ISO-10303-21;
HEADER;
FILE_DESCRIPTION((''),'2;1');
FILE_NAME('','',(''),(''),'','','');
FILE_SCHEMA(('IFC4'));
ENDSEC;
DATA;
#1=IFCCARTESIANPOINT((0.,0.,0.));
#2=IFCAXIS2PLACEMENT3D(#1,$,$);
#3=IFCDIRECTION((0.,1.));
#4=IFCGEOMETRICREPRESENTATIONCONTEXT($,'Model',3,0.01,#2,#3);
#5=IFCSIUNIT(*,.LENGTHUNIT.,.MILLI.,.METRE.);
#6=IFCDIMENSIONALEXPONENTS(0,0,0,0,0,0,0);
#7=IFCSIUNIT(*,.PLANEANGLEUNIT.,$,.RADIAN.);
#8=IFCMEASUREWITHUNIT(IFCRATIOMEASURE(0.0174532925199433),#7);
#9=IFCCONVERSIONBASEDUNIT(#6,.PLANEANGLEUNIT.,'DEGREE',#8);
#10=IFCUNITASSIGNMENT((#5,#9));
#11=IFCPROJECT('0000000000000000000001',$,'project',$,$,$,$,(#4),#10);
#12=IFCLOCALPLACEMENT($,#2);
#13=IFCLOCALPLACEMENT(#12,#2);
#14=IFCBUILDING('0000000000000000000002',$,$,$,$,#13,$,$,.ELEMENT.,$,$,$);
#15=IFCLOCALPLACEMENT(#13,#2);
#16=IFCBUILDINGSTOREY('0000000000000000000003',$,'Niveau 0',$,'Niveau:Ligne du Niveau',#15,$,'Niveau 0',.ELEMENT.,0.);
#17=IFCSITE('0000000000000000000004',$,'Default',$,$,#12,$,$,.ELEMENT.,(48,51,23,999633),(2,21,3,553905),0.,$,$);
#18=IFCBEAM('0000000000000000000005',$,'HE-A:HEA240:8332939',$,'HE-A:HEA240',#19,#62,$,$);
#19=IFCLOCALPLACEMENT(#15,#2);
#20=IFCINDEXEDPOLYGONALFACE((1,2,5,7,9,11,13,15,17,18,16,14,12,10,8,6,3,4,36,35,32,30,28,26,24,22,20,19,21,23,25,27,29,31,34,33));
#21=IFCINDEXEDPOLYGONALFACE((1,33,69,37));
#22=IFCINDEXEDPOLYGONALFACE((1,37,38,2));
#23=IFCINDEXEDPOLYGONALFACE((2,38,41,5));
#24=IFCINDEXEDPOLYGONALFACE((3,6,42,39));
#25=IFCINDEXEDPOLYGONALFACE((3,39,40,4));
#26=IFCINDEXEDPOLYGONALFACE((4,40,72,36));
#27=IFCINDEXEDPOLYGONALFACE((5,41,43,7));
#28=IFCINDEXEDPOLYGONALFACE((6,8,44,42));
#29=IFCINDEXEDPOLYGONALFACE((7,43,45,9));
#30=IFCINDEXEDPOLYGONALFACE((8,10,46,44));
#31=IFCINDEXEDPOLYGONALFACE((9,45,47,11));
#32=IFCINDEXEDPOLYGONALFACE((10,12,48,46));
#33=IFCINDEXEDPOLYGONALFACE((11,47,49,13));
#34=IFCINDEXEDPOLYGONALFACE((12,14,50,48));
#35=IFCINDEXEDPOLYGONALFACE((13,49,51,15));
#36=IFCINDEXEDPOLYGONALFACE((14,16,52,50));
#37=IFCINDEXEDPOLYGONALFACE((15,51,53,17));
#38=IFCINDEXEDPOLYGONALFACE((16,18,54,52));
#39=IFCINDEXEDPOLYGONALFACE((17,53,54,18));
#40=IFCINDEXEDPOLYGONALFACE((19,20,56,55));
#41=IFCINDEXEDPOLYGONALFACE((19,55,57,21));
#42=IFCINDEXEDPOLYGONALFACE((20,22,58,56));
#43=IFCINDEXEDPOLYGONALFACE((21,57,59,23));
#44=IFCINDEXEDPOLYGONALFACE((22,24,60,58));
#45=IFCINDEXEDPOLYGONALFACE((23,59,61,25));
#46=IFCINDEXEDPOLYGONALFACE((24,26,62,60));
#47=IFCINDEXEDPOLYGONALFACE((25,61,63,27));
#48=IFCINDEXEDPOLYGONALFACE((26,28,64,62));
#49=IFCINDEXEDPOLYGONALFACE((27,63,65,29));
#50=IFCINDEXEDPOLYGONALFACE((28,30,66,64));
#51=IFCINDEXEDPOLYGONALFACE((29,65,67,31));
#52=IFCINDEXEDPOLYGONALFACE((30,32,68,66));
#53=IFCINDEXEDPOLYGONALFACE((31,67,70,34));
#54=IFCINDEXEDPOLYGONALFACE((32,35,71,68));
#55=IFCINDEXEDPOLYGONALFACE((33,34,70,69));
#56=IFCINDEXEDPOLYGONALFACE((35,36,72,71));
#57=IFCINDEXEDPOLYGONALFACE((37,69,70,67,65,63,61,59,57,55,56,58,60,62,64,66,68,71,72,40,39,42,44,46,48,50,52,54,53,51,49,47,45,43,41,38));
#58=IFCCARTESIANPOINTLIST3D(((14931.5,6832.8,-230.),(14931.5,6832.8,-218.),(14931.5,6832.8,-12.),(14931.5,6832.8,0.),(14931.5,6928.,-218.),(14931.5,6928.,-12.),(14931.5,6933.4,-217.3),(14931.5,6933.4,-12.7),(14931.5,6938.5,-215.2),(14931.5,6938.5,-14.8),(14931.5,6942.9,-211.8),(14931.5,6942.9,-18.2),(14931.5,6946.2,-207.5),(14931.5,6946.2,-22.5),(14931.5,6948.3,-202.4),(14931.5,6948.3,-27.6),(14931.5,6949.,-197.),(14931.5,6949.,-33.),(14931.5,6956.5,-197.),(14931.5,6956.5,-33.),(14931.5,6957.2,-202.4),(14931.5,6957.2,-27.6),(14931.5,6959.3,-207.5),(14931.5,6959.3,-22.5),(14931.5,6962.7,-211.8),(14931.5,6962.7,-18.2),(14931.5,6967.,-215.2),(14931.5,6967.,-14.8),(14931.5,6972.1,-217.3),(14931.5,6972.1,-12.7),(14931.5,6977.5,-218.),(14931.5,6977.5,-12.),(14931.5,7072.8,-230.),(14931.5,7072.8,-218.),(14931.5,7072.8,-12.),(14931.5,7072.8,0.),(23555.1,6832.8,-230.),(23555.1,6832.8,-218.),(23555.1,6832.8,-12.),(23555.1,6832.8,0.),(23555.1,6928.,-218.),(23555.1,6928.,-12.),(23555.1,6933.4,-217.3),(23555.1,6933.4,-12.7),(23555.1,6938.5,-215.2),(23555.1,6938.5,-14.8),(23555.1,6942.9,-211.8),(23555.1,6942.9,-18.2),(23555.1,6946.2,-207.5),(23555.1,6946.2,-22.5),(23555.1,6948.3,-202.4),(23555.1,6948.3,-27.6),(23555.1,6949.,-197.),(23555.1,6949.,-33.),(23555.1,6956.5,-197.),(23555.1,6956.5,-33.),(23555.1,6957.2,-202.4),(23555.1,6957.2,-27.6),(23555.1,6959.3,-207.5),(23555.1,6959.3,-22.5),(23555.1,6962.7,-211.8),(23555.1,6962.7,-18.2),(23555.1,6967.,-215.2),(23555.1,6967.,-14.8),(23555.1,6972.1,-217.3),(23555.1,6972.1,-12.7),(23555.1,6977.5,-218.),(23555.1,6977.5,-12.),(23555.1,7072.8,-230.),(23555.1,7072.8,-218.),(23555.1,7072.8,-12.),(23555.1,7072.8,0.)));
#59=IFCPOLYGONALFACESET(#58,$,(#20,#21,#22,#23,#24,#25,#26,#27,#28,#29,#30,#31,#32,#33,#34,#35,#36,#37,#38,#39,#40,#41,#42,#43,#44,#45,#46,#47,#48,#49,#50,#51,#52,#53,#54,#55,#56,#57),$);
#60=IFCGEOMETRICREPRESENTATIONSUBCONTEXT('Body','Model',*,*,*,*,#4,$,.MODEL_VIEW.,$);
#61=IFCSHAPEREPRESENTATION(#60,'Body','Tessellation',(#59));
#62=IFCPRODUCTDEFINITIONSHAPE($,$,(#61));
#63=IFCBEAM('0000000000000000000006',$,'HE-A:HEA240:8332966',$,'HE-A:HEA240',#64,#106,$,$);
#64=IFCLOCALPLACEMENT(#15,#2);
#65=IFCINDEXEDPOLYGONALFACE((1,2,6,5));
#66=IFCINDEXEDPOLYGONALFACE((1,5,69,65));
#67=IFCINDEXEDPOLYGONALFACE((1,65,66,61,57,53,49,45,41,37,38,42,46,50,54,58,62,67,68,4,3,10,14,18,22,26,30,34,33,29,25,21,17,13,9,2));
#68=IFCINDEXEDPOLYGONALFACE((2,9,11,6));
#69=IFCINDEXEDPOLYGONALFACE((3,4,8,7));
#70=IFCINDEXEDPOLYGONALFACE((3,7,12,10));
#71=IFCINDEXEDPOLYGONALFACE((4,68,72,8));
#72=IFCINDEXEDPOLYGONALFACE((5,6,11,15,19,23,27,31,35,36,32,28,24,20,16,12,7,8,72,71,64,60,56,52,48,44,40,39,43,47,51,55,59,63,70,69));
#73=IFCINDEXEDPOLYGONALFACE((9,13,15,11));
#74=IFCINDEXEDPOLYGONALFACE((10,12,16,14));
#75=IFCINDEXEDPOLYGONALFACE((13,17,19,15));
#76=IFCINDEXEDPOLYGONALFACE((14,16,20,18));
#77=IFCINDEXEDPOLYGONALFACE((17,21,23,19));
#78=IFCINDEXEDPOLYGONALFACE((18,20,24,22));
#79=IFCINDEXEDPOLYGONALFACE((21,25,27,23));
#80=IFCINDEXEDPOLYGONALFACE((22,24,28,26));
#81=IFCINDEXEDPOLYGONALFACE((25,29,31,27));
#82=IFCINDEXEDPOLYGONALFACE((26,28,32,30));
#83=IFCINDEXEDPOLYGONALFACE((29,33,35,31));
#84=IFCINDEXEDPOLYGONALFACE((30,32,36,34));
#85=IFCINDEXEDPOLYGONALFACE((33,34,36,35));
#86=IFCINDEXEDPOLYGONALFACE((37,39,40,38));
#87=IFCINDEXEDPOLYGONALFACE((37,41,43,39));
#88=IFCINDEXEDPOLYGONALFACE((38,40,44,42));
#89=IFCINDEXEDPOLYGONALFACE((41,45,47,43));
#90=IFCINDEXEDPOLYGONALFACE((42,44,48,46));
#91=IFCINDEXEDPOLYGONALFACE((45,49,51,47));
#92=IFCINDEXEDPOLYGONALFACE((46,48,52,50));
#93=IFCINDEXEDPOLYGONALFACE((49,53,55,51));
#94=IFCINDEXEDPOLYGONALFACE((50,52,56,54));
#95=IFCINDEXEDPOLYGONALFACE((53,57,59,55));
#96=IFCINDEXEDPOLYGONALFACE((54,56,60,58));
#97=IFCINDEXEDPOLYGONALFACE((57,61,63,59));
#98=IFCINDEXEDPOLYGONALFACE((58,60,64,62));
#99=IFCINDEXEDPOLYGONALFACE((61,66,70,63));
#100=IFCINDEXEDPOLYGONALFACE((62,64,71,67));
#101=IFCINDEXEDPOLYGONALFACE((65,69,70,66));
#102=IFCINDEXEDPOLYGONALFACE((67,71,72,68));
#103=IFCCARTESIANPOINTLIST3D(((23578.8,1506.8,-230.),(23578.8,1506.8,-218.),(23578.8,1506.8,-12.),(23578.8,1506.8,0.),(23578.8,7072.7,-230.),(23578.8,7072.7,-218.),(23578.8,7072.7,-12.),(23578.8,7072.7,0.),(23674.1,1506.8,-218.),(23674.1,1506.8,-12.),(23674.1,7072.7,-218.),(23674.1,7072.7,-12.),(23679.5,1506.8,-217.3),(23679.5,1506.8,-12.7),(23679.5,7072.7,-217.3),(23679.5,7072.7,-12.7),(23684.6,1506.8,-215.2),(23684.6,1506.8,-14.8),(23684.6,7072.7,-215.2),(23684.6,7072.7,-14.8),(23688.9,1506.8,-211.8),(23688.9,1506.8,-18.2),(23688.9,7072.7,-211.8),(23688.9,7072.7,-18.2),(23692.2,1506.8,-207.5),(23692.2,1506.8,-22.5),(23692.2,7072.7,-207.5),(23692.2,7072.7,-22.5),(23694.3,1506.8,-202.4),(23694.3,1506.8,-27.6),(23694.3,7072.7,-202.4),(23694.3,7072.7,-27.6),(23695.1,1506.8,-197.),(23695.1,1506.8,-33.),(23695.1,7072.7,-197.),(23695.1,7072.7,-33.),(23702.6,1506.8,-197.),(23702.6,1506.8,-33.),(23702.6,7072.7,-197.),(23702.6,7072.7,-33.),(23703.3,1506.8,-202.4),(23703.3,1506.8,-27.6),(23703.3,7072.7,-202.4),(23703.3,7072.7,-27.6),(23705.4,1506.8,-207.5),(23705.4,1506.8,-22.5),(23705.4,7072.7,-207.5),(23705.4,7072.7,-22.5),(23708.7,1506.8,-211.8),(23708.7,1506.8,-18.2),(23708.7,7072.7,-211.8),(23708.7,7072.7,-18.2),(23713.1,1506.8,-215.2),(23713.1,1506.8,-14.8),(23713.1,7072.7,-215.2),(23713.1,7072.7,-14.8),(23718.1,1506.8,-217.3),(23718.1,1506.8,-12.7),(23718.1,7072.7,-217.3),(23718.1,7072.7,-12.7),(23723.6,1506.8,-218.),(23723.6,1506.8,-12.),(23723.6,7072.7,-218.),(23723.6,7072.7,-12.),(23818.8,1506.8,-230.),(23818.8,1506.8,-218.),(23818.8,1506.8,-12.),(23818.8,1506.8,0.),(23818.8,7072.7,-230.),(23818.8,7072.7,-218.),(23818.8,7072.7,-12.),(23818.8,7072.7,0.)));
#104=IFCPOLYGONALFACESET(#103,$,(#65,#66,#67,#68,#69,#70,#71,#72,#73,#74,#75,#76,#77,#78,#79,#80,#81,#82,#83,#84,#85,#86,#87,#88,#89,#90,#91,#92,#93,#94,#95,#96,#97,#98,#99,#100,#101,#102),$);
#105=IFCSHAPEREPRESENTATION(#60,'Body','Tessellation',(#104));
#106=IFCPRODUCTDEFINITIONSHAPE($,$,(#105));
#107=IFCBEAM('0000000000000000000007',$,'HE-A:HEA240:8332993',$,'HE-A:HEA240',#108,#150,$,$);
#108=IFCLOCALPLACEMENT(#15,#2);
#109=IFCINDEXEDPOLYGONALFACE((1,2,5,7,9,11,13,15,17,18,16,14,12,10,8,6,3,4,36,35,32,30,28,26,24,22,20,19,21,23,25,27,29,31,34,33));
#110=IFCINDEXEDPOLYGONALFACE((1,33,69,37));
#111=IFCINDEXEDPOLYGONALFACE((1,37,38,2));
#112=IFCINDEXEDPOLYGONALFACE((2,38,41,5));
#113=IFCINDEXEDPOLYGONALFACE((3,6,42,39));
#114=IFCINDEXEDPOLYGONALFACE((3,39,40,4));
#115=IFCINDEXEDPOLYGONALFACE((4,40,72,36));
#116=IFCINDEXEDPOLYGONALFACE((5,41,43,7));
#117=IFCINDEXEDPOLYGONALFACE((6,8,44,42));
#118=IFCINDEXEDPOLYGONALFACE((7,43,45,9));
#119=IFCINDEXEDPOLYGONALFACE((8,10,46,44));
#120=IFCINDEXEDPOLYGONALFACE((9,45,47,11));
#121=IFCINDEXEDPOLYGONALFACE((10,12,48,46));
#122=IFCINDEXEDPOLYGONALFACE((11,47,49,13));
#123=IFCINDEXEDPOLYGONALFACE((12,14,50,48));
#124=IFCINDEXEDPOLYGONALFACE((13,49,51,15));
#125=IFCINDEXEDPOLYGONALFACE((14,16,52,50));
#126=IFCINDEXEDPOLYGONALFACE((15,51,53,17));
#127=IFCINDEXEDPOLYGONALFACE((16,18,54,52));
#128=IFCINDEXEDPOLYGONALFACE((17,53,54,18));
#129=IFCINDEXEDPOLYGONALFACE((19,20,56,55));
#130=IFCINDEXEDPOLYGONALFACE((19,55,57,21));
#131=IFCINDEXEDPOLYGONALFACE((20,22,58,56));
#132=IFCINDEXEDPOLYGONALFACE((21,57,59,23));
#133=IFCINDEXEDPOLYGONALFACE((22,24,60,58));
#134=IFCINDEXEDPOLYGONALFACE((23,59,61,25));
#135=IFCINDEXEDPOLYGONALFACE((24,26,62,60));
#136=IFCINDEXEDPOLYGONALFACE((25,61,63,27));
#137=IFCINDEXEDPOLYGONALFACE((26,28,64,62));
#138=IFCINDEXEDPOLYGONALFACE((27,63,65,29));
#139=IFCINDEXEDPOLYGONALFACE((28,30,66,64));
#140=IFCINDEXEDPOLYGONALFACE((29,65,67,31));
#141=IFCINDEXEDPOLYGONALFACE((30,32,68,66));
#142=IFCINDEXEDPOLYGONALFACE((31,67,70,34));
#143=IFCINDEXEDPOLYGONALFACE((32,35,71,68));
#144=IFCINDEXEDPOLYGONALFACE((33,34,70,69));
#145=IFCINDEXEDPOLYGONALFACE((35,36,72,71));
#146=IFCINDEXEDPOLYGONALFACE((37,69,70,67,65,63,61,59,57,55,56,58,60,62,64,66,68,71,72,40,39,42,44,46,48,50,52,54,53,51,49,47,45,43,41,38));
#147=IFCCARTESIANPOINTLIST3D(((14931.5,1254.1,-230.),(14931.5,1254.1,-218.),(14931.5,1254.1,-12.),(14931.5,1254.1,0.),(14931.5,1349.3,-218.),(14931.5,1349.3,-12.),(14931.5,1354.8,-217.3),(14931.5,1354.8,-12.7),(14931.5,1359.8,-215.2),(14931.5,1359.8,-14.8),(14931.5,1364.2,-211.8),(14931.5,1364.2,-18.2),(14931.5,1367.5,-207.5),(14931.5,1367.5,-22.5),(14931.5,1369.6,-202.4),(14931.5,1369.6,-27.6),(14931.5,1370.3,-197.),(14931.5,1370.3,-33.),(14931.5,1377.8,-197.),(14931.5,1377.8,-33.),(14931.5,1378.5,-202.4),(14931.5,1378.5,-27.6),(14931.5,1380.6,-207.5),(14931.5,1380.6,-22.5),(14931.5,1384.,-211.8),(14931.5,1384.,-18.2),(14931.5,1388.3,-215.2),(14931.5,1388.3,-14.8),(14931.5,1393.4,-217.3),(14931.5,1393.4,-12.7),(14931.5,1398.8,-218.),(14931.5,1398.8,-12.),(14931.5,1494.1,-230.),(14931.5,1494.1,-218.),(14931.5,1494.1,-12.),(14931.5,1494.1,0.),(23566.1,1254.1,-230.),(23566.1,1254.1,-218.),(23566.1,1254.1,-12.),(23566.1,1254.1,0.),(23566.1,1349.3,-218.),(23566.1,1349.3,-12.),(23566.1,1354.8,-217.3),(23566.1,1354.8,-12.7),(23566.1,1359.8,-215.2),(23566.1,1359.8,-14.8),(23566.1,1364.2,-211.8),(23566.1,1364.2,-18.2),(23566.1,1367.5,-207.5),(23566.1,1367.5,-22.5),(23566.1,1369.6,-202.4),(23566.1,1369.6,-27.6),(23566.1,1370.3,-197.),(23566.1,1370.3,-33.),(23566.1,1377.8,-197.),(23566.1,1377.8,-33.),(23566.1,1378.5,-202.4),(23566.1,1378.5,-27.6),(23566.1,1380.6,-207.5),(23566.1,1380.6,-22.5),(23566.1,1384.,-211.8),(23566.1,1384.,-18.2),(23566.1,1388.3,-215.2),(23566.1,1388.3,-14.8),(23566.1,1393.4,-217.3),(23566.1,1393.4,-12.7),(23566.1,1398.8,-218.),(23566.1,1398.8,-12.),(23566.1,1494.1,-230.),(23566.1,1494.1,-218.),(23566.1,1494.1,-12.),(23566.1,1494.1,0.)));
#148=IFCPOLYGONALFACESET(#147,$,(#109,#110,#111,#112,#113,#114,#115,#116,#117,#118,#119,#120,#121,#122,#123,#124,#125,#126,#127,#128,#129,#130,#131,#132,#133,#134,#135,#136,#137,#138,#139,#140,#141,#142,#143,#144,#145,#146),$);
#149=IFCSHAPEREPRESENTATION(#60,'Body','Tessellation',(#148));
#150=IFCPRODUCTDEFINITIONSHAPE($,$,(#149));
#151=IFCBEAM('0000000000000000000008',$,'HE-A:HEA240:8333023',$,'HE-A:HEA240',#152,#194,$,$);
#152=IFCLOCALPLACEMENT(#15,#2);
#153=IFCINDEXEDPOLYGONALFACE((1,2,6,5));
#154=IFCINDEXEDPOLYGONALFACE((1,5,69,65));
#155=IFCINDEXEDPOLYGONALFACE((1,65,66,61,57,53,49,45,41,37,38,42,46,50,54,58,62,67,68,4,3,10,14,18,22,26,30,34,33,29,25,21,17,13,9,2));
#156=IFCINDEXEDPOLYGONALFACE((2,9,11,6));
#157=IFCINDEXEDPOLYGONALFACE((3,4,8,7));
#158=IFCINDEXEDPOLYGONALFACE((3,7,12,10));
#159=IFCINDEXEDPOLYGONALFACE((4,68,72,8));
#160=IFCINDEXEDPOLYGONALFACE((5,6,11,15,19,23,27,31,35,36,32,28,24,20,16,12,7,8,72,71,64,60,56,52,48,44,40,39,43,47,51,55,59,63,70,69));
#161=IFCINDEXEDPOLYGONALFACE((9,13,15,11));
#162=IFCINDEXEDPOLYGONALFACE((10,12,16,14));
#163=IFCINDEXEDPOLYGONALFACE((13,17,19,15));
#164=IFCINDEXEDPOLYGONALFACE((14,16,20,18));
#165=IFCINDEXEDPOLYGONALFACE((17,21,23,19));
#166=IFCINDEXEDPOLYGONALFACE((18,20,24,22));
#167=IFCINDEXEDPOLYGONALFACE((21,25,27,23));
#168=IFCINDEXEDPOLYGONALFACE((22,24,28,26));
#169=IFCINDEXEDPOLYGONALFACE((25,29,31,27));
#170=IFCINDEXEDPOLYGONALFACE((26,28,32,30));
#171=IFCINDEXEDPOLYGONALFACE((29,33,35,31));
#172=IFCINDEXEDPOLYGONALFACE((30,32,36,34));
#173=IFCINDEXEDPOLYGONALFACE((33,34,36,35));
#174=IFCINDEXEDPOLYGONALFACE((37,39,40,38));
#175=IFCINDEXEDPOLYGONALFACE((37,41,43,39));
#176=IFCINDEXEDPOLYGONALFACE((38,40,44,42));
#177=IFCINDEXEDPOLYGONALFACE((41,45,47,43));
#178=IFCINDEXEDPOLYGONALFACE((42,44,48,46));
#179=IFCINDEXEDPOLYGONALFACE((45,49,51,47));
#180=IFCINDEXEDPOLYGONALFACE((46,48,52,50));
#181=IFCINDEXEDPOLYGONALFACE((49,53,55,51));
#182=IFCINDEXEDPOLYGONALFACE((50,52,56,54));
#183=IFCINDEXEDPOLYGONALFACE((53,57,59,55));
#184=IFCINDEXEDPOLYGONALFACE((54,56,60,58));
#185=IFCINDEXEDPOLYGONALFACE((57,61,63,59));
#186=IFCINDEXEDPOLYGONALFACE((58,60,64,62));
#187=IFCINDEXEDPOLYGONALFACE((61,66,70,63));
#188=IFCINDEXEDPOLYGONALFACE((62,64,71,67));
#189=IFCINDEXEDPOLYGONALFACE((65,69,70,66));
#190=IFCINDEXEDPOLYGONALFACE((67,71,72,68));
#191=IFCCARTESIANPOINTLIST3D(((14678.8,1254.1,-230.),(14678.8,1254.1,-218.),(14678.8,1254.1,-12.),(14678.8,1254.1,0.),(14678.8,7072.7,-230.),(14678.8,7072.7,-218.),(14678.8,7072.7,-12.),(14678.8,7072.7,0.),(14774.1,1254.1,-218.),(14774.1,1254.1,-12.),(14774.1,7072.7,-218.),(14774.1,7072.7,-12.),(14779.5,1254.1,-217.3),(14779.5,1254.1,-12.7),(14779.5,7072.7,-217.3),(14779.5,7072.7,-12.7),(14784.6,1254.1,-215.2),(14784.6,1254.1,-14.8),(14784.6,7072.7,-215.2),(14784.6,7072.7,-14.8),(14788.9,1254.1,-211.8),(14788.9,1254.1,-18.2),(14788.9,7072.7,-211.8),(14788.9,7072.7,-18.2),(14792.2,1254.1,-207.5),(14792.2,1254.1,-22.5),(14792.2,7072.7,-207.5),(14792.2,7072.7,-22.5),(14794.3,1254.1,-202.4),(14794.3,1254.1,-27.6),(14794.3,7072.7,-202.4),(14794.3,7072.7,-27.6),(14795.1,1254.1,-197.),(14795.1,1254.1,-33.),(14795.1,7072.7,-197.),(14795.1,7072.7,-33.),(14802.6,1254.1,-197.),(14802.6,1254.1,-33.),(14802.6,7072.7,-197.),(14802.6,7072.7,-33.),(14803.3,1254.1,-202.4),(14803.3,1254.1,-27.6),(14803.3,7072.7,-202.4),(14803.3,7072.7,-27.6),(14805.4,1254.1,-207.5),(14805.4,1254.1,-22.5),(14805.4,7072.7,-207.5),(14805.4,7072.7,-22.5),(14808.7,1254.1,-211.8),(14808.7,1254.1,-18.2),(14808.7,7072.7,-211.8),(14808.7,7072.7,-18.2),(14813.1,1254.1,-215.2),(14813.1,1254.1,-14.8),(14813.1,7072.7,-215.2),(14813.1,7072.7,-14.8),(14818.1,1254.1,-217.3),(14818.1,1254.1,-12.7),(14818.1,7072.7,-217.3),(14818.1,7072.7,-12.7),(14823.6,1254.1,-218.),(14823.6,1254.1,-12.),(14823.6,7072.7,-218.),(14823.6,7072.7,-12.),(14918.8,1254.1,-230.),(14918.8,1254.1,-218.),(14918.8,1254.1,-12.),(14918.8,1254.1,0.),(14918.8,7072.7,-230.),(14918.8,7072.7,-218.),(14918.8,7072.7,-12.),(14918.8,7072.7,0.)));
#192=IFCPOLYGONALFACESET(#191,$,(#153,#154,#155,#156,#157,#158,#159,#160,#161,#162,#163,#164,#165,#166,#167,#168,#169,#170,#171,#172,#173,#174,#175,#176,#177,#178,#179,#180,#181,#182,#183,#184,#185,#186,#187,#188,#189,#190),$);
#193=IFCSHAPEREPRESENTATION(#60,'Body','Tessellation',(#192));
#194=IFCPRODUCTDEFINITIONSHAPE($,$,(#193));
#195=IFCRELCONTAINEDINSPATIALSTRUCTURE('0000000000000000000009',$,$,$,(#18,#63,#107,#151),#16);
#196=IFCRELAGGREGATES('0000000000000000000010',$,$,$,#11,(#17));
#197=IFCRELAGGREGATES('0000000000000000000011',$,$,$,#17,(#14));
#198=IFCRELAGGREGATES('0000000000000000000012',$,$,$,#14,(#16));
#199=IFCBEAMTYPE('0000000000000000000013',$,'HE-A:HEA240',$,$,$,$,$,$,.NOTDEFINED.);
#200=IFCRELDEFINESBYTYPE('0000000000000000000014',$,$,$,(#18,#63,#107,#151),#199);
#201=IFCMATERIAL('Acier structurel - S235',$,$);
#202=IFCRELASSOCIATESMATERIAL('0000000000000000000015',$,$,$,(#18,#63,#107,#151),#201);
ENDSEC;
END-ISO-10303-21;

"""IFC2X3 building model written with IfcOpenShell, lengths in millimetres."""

from ifc_helpers import new_model, entity, si_unit, converted_unit, direction, frame, frame_2d, origin, place, context, subcontext, project, spatial, i_section, extrude, material, type_object, element, save


model = new_model("IFC2X3")

# Units and contexts
model_context = context("Model", 3, precision=0.01, world=origin(), true_north=direction((0.0, 1.0)))
body_context = subcontext(model_context, "Body", "Model", "MODEL_VIEW")
ifc_project = project(units=[si_unit("LENGTHUNIT", "METRE", prefix="MILLI"), converted_unit("PLANEANGLEUNIT", "DEGREE", entity("IfcRatioMeasure", 0.0174532925199433), si_unit("PLANEANGLEUNIT", "RADIAN"), dimensions=[0, 0, 0, 0, 0, 0, 0])], contexts=[model_context])

# Site, building, storey
site_placement = place(None, origin())
site = spatial("IfcSite", under=ifc_project, at=site_placement, Name="Default", CompositionType="ELEMENT", RefLatitude=(48, 51, 23, 999633), RefLongitude=(2, 21, 3, 553905), RefElevation=0.0)
building_placement = place(site_placement, origin())
building = spatial("IfcBuilding", under=site, at=building_placement, CompositionType="ELEMENT")
storey_placement = place(building_placement, origin())
storey = spatial("IfcBuildingStorey", under=building, at=storey_placement, Name="Niveau 0", ObjectType="Niveau:Ligne du Niveau", LongName="Niveau 0", CompositionType="ELEMENT", Elevation=0.0)

# Beams
ifc_material_1 = material(Name="Acier structurel - S235")
beam_type = type_object("IfcBeamType", Name="HE-A:HEA240", PredefinedType="NOTDEFINED")
beam_1_placement = place(storey_placement, frame((14798.8, 6952.8, 0.0)))
element("IfcBeam", 1, at=beam_1_placement, inside=storey, type_object=beam_type, material=ifc_material_1, Name="HE-A:HEA240:8332939", ObjectType="HE-A:HEA240", context=body_context, shape_type="SweptSolid", body=[
    extrude(i_section(OverallWidth=240.0, OverallDepth=230.0, WebThickness=7.5, FlangeThickness=12.0, FilletRadius=21.0, at=frame_2d((0.0, 0.0), x_axis=(0.0, 1.0))), frame((132.7, 0.0, -115.0), z_axis=(1.0, 0.0, 0.0), x_axis=(0.0, 0.0, -1.0)), (0.0, 0.0, 1.0), 8623.6),
])
beam_2_placement = place(storey_placement, frame((23698.8, 6952.8, 0.0), z_axis=(0.0, 0.0, 1.0), x_axis=(0.0, -1.0, 0.0)))
element("IfcBeam", 2, at=beam_2_placement, inside=storey, type_object=beam_type, material=ifc_material_1, Name="HE-A:HEA240:8332966", ObjectType="HE-A:HEA240", context=body_context, shape_type="SweptSolid", body=[
    extrude(i_section(OverallWidth=240.0, OverallDepth=230.0, WebThickness=7.5, FlangeThickness=12.0, FilletRadius=21.0, at=frame_2d((0.0, 0.0), x_axis=(0.0, 1.0))), frame((-120.0, 0.0, -115.0), z_axis=(1.0, 0.0, 0.0), x_axis=(0.0, 0.0, -1.0)), (0.0, 0.0, 1.0), 5565.9),
])
beam_3_placement = place(storey_placement, frame((23698.8, 1374.1, 0.0), z_axis=(0.0, 0.0, 1.0), x_axis=(-1.0, 0.0, 0.0)))
element("IfcBeam", 3, at=beam_3_placement, inside=storey, type_object=beam_type, material=ifc_material_1, Name="HE-A:HEA240:8332993", ObjectType="HE-A:HEA240", context=body_context, shape_type="SweptSolid", body=[
    extrude(i_section(OverallWidth=240.0, OverallDepth=230.0, WebThickness=7.5, FlangeThickness=12.0, FilletRadius=21.0, at=frame_2d((0.0, 0.0), x_axis=(0.0, 1.0))), frame((132.7, 0.0, -115.0), z_axis=(1.0, 0.0, 0.0), x_axis=(0.0, 0.0, -1.0)), (0.0, 0.0, 1.0), 8634.6),
])
beam_4_placement = place(storey_placement, frame((14798.8, 6952.8, 0.0), z_axis=(0.0, 0.0, 1.0), x_axis=(0.0, -1.0, 0.0)))
element("IfcBeam", 4, at=beam_4_placement, inside=storey, type_object=beam_type, material=ifc_material_1, Name="HE-A:HEA240:8333023", ObjectType="HE-A:HEA240", context=body_context, shape_type="SweptSolid", body=[
    extrude(i_section(OverallWidth=240.0, OverallDepth=230.0, WebThickness=7.5, FlangeThickness=12.0, FilletRadius=21.0, at=frame_2d((0.0, 0.0), x_axis=(0.0, 1.0))), frame((-120.0, 0.0, -115.0), z_axis=(1.0, 0.0, 0.0), x_axis=(0.0, 0.0, -1.0)), (0.0, 0.0, 1.0), 5818.6),
])

save(model, "model.ifc")
